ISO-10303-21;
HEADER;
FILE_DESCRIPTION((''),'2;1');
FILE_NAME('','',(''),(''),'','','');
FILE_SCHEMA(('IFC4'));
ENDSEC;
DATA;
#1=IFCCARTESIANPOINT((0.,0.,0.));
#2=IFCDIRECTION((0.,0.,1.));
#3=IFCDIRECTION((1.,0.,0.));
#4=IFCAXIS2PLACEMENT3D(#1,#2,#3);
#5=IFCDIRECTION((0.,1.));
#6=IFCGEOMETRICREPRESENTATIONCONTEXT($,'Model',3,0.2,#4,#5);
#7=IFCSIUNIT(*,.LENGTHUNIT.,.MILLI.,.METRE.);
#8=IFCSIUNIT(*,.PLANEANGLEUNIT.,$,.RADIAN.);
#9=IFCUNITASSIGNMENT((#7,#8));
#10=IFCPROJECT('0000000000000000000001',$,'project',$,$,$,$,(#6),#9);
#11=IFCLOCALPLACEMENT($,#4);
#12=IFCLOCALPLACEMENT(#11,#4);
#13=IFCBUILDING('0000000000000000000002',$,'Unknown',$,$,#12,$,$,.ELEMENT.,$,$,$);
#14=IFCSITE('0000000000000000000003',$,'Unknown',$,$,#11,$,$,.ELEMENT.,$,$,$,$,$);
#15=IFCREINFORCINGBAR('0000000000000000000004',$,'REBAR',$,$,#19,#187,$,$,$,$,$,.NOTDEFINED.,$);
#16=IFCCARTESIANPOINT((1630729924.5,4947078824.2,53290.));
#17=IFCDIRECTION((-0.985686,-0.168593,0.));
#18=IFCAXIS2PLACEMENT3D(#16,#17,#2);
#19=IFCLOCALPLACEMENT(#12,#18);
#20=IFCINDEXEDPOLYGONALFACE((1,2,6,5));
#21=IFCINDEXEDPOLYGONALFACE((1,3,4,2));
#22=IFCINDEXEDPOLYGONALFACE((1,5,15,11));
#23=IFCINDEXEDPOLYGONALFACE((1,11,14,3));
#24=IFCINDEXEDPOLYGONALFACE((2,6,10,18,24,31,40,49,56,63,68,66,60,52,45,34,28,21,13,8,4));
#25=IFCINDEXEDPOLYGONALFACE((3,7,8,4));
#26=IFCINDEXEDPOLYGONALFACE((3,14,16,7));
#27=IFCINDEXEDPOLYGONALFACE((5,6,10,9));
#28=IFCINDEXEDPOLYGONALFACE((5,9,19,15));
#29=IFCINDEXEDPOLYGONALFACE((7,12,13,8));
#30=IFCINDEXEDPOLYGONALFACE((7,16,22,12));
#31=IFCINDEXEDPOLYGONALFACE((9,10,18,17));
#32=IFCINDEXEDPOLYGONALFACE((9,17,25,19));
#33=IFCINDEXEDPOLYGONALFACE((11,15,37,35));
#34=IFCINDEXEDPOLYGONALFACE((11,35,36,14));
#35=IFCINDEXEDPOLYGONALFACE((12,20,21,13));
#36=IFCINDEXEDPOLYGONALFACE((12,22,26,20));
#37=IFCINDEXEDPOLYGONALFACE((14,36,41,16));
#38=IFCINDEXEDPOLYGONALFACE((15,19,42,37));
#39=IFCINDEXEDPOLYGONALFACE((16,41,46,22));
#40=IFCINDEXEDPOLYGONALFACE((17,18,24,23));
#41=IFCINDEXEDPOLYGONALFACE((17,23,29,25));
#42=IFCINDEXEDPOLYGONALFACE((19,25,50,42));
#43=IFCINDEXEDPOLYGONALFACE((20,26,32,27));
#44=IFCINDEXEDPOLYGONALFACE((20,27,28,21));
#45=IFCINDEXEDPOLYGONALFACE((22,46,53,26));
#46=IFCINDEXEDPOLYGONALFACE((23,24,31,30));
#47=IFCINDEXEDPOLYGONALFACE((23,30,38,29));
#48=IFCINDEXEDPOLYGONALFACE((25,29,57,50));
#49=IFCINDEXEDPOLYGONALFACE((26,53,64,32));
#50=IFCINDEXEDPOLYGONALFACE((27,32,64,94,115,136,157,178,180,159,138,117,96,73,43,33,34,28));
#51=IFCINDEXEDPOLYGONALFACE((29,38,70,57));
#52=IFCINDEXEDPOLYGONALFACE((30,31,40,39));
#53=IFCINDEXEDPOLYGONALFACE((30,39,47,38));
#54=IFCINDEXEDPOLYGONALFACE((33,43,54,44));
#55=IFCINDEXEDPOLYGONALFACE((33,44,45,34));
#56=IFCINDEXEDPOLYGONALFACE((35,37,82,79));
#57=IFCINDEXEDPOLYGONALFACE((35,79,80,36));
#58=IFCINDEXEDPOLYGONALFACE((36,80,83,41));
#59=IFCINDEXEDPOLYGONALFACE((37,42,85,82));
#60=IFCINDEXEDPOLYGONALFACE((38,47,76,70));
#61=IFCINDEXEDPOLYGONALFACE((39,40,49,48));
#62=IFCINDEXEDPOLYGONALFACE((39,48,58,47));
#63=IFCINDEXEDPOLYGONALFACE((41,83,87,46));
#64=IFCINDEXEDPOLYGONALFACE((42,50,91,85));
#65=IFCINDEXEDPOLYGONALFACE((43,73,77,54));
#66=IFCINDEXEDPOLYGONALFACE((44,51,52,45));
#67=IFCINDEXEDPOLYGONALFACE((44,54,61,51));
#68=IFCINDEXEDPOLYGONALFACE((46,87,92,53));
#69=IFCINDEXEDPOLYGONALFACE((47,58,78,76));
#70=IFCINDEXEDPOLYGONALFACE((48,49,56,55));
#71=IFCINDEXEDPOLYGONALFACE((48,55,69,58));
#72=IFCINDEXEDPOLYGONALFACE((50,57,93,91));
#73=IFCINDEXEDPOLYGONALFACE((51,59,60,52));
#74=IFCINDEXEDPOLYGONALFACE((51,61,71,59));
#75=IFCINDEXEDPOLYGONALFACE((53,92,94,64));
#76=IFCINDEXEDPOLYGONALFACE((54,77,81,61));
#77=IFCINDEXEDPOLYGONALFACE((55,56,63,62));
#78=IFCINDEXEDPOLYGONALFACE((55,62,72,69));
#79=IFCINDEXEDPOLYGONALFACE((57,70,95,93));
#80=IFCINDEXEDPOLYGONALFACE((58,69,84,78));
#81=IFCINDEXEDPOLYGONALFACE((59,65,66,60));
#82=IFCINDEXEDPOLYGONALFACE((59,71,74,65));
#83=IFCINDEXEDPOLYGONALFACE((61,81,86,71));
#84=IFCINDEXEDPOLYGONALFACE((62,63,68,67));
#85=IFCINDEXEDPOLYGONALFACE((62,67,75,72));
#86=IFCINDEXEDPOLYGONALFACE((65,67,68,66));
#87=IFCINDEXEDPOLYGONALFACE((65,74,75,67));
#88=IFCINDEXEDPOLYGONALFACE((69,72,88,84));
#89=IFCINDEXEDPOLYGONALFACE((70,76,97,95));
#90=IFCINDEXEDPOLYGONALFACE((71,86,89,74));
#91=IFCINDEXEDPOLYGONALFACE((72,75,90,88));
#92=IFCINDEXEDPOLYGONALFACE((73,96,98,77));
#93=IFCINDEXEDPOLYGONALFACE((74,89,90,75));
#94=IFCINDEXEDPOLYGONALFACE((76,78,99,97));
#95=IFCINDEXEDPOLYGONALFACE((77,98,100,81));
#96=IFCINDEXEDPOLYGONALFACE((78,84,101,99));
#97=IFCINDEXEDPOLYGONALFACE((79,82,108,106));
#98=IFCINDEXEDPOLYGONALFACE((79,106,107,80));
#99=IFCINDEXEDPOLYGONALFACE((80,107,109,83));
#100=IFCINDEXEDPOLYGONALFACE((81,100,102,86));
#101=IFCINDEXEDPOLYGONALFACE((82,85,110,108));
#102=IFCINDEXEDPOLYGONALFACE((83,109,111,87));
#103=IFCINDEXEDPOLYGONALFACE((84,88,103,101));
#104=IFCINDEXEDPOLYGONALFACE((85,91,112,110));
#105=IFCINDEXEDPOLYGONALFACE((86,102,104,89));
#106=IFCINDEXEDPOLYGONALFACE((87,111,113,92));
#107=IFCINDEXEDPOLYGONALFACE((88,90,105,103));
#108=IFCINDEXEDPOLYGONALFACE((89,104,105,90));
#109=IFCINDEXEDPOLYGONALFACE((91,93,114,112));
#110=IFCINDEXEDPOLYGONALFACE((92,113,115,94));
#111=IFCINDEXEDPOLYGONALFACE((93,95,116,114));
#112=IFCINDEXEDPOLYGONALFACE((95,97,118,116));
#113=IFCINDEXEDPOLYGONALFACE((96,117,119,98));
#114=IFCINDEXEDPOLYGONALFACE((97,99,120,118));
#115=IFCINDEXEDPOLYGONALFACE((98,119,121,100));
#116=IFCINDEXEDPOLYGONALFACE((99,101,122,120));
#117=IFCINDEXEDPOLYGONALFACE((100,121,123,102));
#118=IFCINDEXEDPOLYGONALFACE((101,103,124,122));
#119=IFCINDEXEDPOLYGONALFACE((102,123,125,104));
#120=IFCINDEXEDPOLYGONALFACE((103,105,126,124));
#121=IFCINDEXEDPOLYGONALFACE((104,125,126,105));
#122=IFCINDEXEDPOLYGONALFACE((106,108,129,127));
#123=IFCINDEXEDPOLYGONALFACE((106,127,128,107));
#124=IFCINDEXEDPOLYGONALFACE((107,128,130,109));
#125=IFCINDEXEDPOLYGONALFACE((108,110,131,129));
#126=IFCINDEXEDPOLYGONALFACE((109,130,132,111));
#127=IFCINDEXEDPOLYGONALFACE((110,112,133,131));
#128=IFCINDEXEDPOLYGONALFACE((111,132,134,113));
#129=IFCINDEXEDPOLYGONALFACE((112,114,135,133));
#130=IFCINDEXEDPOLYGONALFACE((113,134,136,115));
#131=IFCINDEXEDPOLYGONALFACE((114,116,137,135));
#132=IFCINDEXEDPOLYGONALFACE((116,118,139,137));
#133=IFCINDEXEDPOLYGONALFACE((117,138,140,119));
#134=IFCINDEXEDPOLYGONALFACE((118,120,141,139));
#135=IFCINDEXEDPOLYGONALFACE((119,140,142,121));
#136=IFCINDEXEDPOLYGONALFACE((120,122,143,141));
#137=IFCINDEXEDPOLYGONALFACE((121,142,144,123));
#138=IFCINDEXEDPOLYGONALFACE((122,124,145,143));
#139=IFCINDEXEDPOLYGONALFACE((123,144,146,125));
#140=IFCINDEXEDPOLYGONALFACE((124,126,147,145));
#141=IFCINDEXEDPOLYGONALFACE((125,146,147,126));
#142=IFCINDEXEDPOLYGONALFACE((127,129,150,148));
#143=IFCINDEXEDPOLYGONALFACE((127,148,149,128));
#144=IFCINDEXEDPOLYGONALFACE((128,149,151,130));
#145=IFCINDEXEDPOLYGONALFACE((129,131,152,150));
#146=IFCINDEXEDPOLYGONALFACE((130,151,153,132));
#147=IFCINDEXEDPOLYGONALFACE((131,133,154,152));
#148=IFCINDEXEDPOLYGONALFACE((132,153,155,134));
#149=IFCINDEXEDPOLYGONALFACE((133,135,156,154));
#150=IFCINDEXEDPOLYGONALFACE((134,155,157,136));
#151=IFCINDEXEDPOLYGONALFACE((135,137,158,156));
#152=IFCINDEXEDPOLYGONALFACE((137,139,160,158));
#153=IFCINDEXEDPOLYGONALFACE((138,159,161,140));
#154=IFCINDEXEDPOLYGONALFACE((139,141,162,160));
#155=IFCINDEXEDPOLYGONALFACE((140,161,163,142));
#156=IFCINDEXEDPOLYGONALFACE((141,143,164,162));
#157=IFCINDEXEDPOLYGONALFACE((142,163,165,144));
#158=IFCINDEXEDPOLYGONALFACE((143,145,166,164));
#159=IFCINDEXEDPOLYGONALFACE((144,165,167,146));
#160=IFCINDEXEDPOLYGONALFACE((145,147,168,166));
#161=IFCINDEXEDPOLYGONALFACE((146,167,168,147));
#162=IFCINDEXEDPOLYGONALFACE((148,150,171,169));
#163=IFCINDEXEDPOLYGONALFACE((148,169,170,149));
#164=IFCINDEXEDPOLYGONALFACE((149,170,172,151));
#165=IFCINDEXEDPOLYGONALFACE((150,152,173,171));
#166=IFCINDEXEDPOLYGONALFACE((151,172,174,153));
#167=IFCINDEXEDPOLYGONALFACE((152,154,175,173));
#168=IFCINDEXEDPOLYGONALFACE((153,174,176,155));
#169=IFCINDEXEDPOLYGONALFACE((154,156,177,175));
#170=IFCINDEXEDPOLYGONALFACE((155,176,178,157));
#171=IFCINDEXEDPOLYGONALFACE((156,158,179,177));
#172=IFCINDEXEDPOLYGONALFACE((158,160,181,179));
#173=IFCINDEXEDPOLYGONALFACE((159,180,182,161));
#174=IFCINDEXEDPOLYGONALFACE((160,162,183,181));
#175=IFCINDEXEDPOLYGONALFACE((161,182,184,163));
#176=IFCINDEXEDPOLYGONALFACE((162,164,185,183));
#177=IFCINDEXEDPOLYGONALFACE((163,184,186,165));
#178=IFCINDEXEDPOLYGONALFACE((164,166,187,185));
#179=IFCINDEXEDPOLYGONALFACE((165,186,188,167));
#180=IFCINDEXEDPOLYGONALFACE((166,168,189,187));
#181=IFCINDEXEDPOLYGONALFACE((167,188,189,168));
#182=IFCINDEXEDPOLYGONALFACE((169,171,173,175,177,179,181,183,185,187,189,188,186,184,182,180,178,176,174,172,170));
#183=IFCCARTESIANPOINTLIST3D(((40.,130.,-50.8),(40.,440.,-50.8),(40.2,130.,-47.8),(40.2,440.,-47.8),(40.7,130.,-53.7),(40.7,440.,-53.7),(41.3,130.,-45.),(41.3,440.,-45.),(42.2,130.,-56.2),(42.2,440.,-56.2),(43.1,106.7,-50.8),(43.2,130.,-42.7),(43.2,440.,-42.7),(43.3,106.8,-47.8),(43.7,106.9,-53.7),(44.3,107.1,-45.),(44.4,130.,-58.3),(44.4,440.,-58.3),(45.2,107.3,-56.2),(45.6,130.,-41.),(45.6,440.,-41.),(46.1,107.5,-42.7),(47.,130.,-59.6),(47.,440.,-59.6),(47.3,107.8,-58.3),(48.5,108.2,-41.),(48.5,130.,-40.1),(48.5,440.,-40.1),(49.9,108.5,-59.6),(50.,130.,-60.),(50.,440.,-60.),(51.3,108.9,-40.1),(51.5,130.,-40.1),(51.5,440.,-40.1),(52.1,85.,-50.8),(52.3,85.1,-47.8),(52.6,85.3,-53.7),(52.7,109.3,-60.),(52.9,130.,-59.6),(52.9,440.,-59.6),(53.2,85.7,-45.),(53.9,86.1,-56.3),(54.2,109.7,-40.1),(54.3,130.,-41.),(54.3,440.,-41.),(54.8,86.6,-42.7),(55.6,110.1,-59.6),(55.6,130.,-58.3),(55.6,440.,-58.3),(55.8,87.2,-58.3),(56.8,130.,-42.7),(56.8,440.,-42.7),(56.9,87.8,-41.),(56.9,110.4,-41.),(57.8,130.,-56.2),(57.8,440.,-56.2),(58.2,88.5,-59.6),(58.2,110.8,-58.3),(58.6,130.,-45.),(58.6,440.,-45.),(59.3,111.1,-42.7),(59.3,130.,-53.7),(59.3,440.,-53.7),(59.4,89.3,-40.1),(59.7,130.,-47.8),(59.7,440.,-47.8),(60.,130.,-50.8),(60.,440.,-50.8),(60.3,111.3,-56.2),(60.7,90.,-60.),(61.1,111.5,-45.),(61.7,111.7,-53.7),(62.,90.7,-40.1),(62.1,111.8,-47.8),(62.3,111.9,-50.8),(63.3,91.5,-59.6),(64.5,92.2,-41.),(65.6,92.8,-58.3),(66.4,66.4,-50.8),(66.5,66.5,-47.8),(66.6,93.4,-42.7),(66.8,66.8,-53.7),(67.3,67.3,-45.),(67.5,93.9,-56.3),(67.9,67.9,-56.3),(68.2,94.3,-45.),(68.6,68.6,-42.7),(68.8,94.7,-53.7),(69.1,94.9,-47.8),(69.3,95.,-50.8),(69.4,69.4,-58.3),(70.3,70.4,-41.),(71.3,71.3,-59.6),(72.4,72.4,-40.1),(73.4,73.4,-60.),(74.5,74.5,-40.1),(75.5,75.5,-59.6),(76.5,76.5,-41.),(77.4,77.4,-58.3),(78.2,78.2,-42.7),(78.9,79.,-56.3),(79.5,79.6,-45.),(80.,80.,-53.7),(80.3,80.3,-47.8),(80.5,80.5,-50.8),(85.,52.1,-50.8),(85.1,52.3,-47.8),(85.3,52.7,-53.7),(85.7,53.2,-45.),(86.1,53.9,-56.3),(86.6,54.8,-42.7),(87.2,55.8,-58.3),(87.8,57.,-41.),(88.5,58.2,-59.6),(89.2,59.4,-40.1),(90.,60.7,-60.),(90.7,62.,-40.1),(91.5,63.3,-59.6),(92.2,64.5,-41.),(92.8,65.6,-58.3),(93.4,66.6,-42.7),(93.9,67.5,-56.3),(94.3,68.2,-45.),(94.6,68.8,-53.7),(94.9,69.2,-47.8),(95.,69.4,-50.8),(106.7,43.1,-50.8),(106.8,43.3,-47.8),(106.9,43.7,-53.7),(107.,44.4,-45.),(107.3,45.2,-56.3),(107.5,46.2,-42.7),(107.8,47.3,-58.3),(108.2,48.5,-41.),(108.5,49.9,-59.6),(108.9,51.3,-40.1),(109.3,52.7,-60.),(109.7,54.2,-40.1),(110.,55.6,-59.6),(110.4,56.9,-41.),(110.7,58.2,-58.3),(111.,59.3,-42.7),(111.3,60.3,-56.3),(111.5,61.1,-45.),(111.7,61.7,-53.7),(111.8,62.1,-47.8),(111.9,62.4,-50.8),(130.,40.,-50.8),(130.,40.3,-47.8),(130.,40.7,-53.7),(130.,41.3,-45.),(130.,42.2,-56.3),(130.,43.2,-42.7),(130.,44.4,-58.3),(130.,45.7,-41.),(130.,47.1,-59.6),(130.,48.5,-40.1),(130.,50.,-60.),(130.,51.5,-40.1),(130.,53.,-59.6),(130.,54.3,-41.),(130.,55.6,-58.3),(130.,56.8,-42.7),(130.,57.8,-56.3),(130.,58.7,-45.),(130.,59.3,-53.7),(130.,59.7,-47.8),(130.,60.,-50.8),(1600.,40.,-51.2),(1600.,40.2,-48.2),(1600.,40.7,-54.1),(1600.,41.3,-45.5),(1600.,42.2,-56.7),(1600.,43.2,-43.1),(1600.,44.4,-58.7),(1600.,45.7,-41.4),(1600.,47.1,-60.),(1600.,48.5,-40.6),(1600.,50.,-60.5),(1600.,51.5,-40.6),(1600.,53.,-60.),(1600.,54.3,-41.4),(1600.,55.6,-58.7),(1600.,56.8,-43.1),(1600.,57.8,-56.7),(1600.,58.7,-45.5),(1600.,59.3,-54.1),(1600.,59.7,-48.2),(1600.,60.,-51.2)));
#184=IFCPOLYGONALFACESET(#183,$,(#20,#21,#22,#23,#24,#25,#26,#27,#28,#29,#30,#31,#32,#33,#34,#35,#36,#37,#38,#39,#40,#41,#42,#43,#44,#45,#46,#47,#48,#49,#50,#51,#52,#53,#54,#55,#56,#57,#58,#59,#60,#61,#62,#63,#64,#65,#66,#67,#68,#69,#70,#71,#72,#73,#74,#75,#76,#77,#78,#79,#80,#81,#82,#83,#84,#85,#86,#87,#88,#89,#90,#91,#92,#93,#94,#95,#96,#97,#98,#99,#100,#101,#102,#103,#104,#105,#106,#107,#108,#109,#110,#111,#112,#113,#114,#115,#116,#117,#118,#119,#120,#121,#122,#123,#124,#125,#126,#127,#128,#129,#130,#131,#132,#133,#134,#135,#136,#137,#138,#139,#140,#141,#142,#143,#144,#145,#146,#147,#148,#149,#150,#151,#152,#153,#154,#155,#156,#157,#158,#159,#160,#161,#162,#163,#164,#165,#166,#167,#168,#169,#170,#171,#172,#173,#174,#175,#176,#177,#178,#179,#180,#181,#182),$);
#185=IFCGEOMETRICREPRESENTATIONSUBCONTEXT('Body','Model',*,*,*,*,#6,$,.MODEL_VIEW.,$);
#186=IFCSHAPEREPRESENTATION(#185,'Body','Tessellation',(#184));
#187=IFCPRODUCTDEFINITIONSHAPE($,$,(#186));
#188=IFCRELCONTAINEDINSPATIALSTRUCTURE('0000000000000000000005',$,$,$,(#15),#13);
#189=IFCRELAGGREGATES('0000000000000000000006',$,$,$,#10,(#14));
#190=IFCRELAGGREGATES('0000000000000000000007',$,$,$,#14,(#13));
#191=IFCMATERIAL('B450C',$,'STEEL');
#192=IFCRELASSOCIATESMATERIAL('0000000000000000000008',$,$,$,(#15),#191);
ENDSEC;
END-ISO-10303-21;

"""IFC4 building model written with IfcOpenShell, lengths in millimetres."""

from ifc_helpers import new_model, entity, si_unit, direction, frame, origin_with_axes, place, context, subcontext, project, spatial, material, element, save


model = new_model("IFC4")

# Units and contexts
model_context = context("Model", 3, precision=0.2, world=origin_with_axes(), true_north=direction((0.0, 1.0)))
body_context = subcontext(model_context, "Body", "Model", "MODEL_VIEW")
ifc_project = project(units=[si_unit("LENGTHUNIT", "METRE", prefix="MILLI"), si_unit("PLANEANGLEUNIT", "RADIAN")], contexts=[model_context])

# Site, building
site_placement = place(None, origin_with_axes())
site = spatial("IfcSite", under=ifc_project, at=site_placement, Name="Unknown", CompositionType="ELEMENT")
building_placement = place(site_placement, origin_with_axes())
building = spatial("IfcBuilding", under=site, at=building_placement, Name="Unknown", CompositionType="ELEMENT")

# Reinforcing bar
ifc_material = material(Name="B450C", Category="STEEL")
reinforcing_bar_1_placement = place(building_placement, frame((1630729924.5, 4947078824.2, 53290.0), z_axis=(-0.985686, -0.168593, 0.0), x_axis=(0.0, 0.0, 1.0)))
element("IfcReinforcingBar", 1, at=reinforcing_bar_1_placement, inside=building, material=ifc_material, Name="REBAR", PredefinedType="NOTDEFINED", context=body_context, shape_type="AdvancedSweptSolid", body=[
    entity("IfcSweptDiskSolid", entity("IfcIndexedPolyCurve", entity("IfcCartesianPointList3D", [[50.0, 440.0, -50.0], [50.0, 130.0, -50.0], [73.4, 73.4, -50.0], [130.0, 50.0, -50.0], [1600.0, 50.0, -50.5]]), [entity("IfcLineIndex", [1, 2]), entity("IfcArcIndex", [2, 3, 4]), entity("IfcLineIndex", [4, 5])]), 10.0),
])

save(model, "model.ifc")
